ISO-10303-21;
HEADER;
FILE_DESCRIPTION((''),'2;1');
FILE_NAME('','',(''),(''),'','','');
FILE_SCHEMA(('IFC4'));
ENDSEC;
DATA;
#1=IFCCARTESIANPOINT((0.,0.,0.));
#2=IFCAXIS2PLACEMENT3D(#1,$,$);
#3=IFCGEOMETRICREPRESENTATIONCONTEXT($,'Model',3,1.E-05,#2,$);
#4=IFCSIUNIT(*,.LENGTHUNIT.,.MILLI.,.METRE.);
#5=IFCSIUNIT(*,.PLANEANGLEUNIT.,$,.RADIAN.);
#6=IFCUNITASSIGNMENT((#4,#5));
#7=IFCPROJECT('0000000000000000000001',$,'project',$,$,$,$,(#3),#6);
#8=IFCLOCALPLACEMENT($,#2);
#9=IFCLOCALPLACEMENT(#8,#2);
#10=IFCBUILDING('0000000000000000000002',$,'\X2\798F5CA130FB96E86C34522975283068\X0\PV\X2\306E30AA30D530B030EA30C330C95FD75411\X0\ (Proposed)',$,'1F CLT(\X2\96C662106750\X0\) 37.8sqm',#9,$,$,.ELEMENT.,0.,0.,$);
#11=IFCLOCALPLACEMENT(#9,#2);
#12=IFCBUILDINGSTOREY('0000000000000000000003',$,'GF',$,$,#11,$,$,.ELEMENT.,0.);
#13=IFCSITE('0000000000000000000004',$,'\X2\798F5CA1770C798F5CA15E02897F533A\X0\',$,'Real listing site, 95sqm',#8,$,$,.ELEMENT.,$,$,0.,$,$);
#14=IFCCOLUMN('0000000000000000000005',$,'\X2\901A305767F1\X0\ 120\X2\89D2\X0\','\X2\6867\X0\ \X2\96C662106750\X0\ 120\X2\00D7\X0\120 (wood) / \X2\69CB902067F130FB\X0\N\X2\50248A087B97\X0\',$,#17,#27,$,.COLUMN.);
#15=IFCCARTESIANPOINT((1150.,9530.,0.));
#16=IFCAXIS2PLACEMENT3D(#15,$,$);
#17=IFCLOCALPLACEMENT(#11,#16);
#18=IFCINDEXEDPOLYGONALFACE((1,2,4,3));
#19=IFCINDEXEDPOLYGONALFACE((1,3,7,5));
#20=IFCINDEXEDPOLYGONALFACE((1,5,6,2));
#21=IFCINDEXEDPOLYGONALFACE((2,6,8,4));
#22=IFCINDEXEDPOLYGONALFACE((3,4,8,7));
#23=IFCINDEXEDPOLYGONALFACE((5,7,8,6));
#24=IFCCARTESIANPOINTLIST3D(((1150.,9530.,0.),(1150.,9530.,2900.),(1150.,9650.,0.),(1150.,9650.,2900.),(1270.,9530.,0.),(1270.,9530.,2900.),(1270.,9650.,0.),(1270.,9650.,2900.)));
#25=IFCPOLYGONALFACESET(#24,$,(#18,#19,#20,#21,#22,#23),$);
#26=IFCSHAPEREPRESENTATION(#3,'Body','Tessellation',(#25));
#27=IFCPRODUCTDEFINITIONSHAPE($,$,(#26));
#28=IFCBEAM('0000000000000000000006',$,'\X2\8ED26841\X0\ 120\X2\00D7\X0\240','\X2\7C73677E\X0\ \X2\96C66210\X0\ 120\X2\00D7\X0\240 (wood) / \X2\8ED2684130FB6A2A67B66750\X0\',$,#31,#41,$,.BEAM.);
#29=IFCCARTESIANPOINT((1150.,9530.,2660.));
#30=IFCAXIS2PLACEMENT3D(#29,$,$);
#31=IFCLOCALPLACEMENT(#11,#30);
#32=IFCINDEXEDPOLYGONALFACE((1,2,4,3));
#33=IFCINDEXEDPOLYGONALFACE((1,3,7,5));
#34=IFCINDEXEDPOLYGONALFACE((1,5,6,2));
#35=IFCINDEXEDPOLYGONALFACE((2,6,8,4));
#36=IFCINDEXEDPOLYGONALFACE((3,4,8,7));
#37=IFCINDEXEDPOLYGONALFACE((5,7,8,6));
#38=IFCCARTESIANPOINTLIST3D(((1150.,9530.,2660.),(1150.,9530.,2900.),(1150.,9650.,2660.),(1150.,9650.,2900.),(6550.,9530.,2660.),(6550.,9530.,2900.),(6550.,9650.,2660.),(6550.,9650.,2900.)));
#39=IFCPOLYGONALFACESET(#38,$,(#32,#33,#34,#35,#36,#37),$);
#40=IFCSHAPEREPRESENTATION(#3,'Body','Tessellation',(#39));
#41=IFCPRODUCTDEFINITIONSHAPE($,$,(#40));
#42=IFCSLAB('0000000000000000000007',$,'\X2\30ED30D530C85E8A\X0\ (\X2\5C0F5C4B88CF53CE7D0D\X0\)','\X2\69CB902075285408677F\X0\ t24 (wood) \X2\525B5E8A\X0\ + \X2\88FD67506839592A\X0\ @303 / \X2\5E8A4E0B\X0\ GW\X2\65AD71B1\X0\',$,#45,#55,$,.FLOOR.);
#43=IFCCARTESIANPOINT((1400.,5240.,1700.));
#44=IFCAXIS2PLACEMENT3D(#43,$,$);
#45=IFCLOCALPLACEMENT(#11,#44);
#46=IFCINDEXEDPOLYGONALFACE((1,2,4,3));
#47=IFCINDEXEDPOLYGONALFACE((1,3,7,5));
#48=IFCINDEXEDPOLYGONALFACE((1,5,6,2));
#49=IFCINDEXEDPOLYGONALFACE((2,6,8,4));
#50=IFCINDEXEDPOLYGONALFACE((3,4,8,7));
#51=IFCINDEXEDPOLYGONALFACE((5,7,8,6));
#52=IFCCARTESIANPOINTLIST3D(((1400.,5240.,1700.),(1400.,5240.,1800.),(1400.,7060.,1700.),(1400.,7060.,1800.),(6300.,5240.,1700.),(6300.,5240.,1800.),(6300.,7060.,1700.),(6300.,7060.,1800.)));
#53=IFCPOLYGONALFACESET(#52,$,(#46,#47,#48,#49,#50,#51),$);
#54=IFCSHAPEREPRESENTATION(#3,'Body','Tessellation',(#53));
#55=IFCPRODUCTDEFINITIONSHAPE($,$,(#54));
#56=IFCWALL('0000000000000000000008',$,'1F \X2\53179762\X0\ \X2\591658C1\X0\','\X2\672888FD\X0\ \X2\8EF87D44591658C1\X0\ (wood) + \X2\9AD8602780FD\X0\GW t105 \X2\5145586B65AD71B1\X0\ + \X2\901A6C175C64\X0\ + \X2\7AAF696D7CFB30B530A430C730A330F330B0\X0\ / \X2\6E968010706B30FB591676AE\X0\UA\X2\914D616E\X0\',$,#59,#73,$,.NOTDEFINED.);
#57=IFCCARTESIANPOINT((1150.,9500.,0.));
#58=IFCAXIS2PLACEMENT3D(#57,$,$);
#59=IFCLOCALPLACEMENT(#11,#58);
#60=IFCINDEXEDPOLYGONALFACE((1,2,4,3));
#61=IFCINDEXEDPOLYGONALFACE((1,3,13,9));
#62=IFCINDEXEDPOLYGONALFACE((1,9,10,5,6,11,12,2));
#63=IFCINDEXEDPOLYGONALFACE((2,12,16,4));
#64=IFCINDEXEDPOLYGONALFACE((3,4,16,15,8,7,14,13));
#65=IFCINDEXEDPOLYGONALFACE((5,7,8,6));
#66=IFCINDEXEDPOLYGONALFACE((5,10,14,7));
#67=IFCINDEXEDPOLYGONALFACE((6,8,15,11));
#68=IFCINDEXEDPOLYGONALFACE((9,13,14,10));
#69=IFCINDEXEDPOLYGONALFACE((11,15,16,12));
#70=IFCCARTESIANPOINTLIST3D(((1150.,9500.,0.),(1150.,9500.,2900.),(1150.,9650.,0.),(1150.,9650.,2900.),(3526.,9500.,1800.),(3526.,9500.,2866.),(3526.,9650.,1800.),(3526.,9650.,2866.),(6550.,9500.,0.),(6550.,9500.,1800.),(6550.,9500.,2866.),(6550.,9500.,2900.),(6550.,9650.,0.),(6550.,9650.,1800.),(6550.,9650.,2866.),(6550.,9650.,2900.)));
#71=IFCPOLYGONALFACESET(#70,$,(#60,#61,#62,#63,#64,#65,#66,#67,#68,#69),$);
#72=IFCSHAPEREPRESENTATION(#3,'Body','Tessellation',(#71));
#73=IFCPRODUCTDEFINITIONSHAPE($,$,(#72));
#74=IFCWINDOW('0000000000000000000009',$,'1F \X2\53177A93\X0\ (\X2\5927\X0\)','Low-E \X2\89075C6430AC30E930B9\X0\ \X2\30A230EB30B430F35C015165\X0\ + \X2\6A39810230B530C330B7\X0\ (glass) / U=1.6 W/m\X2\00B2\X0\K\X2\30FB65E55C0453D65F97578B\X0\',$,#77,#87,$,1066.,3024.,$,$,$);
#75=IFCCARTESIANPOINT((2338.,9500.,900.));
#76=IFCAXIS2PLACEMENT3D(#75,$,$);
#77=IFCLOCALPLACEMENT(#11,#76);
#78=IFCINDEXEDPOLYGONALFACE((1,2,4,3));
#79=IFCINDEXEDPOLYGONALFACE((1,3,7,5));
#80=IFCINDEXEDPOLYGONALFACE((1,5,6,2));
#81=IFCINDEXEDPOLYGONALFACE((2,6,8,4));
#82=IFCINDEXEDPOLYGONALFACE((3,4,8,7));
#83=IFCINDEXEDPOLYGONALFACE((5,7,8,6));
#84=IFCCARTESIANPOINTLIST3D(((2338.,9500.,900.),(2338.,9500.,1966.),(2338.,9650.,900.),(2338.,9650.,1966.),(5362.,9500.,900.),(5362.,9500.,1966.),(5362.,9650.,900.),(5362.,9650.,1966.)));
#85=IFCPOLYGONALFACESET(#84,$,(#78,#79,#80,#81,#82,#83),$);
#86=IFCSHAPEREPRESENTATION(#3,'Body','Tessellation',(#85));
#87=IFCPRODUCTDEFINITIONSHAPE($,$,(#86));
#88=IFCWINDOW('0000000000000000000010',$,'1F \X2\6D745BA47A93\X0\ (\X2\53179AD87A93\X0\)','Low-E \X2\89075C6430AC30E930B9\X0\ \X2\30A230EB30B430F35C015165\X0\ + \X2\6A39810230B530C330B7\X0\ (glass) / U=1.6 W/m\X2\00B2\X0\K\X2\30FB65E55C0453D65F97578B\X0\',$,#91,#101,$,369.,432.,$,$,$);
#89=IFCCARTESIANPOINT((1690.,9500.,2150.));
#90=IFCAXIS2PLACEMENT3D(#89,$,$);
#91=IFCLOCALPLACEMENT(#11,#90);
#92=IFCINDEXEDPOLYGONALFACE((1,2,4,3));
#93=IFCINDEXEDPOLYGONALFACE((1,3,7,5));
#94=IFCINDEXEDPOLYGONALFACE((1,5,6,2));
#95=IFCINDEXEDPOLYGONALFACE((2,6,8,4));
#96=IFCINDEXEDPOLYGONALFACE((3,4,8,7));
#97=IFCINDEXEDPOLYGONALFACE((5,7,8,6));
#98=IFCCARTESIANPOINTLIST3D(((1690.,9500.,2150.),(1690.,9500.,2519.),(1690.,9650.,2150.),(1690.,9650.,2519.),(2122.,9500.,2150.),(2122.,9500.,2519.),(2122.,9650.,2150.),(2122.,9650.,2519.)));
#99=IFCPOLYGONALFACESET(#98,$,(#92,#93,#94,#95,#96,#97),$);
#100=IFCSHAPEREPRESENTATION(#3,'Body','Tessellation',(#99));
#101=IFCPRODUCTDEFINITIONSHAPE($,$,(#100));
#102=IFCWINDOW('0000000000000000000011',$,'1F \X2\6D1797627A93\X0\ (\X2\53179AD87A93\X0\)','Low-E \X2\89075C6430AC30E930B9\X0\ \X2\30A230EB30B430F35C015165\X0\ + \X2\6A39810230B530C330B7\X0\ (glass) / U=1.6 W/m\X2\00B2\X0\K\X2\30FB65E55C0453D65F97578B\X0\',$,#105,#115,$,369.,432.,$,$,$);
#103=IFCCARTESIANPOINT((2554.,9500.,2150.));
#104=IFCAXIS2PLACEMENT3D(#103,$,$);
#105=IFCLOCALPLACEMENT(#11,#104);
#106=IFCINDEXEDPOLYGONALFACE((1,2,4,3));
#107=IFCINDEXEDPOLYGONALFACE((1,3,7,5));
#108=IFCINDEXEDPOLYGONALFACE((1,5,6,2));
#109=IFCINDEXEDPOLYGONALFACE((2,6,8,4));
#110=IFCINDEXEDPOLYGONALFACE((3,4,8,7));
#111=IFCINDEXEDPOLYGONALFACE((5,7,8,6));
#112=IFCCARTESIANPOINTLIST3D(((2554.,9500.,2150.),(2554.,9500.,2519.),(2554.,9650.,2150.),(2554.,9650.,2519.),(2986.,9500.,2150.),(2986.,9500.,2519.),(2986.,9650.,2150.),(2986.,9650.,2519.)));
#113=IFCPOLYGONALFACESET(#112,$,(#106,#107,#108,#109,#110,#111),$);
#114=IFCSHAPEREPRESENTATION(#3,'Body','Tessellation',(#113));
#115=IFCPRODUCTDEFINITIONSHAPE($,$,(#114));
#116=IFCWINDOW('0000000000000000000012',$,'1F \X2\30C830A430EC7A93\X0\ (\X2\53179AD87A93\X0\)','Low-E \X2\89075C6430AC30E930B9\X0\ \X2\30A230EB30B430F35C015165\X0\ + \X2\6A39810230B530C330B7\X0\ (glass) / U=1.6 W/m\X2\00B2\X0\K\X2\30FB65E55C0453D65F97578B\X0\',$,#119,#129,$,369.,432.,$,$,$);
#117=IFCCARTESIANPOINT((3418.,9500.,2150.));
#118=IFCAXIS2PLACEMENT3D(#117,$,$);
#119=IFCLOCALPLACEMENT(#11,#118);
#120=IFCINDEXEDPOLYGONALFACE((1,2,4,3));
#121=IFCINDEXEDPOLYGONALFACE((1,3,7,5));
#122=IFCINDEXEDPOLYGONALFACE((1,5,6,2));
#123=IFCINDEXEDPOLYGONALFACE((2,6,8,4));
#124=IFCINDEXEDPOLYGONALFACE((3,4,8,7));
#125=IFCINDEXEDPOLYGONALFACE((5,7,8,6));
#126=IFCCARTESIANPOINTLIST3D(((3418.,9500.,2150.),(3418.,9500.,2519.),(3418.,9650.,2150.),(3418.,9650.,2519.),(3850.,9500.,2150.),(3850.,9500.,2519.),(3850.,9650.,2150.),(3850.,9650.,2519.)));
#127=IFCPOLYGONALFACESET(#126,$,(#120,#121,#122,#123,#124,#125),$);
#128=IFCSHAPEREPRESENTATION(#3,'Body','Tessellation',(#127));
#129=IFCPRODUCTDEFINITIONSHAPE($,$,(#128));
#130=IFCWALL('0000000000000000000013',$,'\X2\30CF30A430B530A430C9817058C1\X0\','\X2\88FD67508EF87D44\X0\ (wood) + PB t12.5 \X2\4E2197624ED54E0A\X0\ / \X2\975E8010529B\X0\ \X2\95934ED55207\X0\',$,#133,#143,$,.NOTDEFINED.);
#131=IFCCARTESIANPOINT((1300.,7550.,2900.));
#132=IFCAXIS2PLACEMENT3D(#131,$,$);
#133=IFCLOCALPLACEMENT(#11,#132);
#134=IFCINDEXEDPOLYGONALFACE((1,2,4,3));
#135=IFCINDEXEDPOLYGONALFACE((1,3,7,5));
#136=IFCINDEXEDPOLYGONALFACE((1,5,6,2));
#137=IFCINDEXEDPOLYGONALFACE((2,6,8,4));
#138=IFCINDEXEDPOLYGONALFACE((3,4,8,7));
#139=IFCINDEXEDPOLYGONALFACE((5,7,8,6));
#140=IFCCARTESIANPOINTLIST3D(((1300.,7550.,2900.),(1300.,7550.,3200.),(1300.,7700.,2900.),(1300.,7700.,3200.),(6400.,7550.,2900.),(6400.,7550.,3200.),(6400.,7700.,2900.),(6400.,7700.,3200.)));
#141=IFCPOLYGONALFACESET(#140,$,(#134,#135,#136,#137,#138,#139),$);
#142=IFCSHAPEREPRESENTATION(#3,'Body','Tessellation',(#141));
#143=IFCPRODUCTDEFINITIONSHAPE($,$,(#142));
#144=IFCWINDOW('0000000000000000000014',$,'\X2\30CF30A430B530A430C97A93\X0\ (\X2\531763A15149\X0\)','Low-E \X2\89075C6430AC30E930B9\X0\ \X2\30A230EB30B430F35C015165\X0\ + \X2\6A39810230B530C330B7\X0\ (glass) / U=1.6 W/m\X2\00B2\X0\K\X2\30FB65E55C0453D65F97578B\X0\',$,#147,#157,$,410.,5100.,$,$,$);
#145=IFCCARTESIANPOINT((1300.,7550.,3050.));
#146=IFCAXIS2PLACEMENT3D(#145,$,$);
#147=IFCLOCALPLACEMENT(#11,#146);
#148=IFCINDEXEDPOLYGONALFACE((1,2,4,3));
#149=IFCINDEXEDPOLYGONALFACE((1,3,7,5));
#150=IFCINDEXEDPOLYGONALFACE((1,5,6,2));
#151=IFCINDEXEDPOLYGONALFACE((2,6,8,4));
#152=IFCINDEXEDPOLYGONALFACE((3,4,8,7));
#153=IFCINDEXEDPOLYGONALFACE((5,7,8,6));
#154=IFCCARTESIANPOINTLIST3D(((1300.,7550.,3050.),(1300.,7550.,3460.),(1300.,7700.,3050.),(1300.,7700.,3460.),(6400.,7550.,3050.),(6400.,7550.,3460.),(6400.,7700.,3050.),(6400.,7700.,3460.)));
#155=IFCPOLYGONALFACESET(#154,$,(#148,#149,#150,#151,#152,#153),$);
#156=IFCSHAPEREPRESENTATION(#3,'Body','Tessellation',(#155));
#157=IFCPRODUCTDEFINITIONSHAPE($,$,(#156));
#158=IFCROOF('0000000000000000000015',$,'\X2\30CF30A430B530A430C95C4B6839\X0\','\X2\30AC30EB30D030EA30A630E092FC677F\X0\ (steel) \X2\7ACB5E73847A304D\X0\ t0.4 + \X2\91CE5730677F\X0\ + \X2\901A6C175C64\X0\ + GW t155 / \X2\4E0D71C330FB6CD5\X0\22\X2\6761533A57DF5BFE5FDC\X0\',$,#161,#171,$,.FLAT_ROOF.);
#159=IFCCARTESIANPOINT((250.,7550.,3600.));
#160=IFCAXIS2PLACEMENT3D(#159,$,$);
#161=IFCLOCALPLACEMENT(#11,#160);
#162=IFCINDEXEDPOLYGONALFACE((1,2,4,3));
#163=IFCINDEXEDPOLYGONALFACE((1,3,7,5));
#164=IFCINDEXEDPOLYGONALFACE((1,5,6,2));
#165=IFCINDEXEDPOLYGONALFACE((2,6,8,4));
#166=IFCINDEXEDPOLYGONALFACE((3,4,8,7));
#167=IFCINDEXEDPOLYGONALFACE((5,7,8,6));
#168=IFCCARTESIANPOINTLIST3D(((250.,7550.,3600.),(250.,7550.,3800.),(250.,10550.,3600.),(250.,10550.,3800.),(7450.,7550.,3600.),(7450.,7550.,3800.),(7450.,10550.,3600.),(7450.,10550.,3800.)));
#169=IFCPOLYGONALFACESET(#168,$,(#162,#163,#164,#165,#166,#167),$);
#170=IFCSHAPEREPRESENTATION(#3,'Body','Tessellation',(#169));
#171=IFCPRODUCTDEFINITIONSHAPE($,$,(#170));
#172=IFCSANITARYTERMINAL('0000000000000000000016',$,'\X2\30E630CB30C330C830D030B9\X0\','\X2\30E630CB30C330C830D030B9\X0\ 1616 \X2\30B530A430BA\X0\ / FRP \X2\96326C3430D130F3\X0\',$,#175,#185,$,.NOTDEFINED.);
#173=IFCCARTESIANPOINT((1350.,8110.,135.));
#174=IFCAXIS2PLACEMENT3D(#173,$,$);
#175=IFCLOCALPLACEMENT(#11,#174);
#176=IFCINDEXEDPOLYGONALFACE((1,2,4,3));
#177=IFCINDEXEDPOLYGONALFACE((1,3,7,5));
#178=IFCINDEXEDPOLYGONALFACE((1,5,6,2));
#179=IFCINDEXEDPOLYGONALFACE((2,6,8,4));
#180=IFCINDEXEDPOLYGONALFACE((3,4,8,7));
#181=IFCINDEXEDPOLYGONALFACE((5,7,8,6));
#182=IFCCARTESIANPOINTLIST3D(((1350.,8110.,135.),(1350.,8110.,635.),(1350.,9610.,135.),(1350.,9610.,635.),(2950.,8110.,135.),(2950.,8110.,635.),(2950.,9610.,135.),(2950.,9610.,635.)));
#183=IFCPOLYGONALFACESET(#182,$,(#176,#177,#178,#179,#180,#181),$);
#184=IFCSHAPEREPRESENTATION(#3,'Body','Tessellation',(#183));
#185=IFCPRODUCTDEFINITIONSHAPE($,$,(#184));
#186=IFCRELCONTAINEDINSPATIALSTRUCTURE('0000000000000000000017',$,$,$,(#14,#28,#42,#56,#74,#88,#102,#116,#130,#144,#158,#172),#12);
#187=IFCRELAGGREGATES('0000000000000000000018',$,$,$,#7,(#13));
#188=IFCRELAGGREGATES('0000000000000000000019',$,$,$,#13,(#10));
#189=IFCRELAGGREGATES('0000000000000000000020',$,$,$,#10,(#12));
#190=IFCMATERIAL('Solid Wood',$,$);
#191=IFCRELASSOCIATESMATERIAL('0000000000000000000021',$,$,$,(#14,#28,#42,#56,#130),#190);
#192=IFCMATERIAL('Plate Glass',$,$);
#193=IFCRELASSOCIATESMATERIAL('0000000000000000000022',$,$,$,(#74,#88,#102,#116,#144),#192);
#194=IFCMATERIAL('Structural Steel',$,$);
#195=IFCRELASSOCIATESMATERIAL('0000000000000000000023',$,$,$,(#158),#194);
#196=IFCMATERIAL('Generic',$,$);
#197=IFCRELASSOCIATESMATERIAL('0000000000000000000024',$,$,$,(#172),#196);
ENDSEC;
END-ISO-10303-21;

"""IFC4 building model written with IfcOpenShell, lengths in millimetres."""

from ifc_helpers import new_model, si_unit, frame, frame_2d, origin, place, context, project, spatial, rectangle, extrude, material, element, fill, save


model = new_model("IFC4")

# Units and contexts
model_context = context("Model", 3, precision=1e-05, world=origin())
ifc_project = project(units=[si_unit("LENGTHUNIT", "METRE", prefix="MILLI"), si_unit("PLANEANGLEUNIT", "RADIAN")], contexts=[model_context])

# Site, building, storey
site_placement = place(None, origin())
site = spatial("IfcSite", under=ifc_project, at=site_placement, Name="福岡県福岡市西区", ObjectType="Real listing site, 95sqm", CompositionType="ELEMENT", RefElevation=0.0)
building_placement = place(site_placement, origin())
building = spatial("IfcBuilding", under=site, at=building_placement, Name="福岡・雨水利用とPVのオフグリッド志向 (Proposed)", ObjectType="1F CLT(集成材) 37.8sqm", CompositionType="ELEMENT", ElevationOfRefHeight=0.0, ElevationOfTerrain=0.0)
storey_placement = place(building_placement, origin())
storey = spatial("IfcBuildingStorey", under=building, at=storey_placement, Name="GF", CompositionType="ELEMENT", Elevation=0.0)

# Column
ifc_material_1 = material(Name="Solid Wood")
column_1_placement = place(storey_placement, frame((1150.0, 9530.0, 0.0)))
element("IfcColumn", 1, at=column_1_placement, inside=storey, material=ifc_material_1, Name="通し柱 120角", Description="桧 集成材 120×120 (wood) / 構造柱・N値計算", PredefinedType="COLUMN", context=model_context, shape_type="SweptSolid", body=[
    extrude(rectangle(XDim=120.0, YDim=120.0, at=frame_2d((60.0, 60.0))), frame((1150.0, 9530.0, 0.0)), (0.0, 0.0, 1.0), 2900.0),
])

# Beam
beam_1_placement = place(storey_placement, frame((1150.0, 9530.0, 2660.0)))
element("IfcBeam", 2, at=beam_1_placement, inside=storey, material=ifc_material_1, Name="軒桁 120×240", Description="米松 集成 120×240 (wood) / 軒桁・横架材", PredefinedType="BEAM", context=model_context, shape_type="SweptSolid", body=[
    extrude(rectangle(XDim=5400.0, YDim=120.0, at=frame_2d((2700.0, 60.0))), frame((1150.0, 9530.0, 2660.0)), (0.0, 0.0, 1.0), 240.0),
])

# Slab
slab_placement = place(storey_placement, frame((1400.0, 5240.0, 1700.0)))
element("IfcSlab", 3, at=slab_placement, inside=storey, material=ifc_material_1, Name="ロフト床 (小屋裏収納)", Description="構造用合板 t24 (wood) 剛床 + 製材根太 @303 / 床下 GW断熱", PredefinedType="FLOOR", context=model_context, shape_type="SweptSolid", body=[
    extrude(rectangle(XDim=4900.0, YDim=1820.0, at=frame_2d((2450.0, 910.0))), frame((1400.0, 5240.0, 1700.0)), (0.0, 0.0, 1.0), 100.0),
])

# Wall, openings, windows
wall_1_placement = place(storey_placement, frame((1150.0, 9500.0, 0.0)))
wall_1 = element("IfcWall", 4, at=wall_1_placement, inside=storey, material=ifc_material_1, Name="1F 北面 外壁", Description="木製 軸組外壁 (wood) + 高性能GW t105 充填断熱 + 通気層 + 窯業系サイディング / 準耐火・外皮UA配慮", PredefinedType="NOTDEFINED", context=model_context, shape_type="SweptSolid", body=[
    extrude(rectangle(XDim=5400.0, YDim=150.0, at=frame_2d((2700.0, 75.0))), frame((1150.0, 9500.0, 0.0)), (0.0, 0.0, 1.0), 2900.0),
])
opening_1_placement = place(storey_placement, frame((2338.0, 9500.0, 900.0)))
opening_1 = element("IfcOpeningElement", 5, at=opening_1_placement, cuts=wall_1, PredefinedType="NOTDEFINED", context=model_context, shape_type="SweptSolid", body=[
    extrude(rectangle(XDim=3024.0, YDim=150.0, at=frame_2d((1512.0, 75.0))), frame((2338.0, 9500.0, 900.0)), (0.0, 0.0, 1.0), 1066.0),
])
opening_2_placement = place(storey_placement, frame((1690.0, 9500.0, 2150.0)))
opening_2 = element("IfcOpeningElement", 6, at=opening_2_placement, cuts=wall_1, PredefinedType="NOTDEFINED", context=model_context, shape_type="SweptSolid", body=[
    extrude(rectangle(XDim=432.0, YDim=150.0, at=frame_2d((216.0, 75.0))), frame((1690.0, 9500.0, 2150.0)), (0.0, 0.0, 1.0), 369.0),
])
opening_3_placement = place(storey_placement, frame((2554.0, 9500.0, 2150.0)))
opening_3 = element("IfcOpeningElement", 7, at=opening_3_placement, cuts=wall_1, PredefinedType="NOTDEFINED", context=model_context, shape_type="SweptSolid", body=[
    extrude(rectangle(XDim=432.0, YDim=150.0, at=frame_2d((216.0, 75.0))), frame((2554.0, 9500.0, 2150.0)), (0.0, 0.0, 1.0), 369.0),
])
opening_4_placement = place(storey_placement, frame((3418.0, 9500.0, 2150.0)))
opening_4 = element("IfcOpeningElement", 8, at=opening_4_placement, cuts=wall_1, PredefinedType="NOTDEFINED", context=model_context, shape_type="SweptSolid", body=[
    extrude(rectangle(XDim=432.0, YDim=150.0, at=frame_2d((216.0, 75.0))), frame((3418.0, 9500.0, 2150.0)), (0.0, 0.0, 1.0), 369.0),
])
ifc_material_2 = material(Name="Plate Glass")
window_1_placement = place(storey_placement, frame((2338.0, 9500.0, 900.0)))
window_1 = element("IfcWindow", 9, at=window_1_placement, inside=storey, material=ifc_material_2, Name="1F 北窓 (大)", Description="Low-E 複層ガラス アルゴン封入 + 樹脂サッシ (glass) / U=1.6 W/m²K・日射取得型", OverallHeight=1066.0, OverallWidth=3024.0, context=model_context, shape_type="SweptSolid", body=[
    extrude(rectangle(XDim=3024.0, YDim=150.0, at=frame_2d((1512.0, 75.0))), frame((2338.0, 9500.0, 900.0)), (0.0, 0.0, 1.0), 1066.0),
])
fill(opening_1, window_1)
window_2_placement = place(storey_placement, frame((1690.0, 9500.0, 2150.0)))
window_2 = element("IfcWindow", 10, at=window_2_placement, inside=storey, material=ifc_material_2, Name="1F 浴室窓 (北高窓)", Description="Low-E 複層ガラス アルゴン封入 + 樹脂サッシ (glass) / U=1.6 W/m²K・日射取得型", OverallHeight=369.0, OverallWidth=432.0, context=model_context, shape_type="SweptSolid", body=[
    extrude(rectangle(XDim=432.0, YDim=150.0, at=frame_2d((216.0, 75.0))), frame((1690.0, 9500.0, 2150.0)), (0.0, 0.0, 1.0), 369.0),
])
fill(opening_2, window_2)
window_3_placement = place(storey_placement, frame((2554.0, 9500.0, 2150.0)))
window_3 = element("IfcWindow", 11, at=window_3_placement, inside=storey, material=ifc_material_2, Name="1F 洗面窓 (北高窓)", Description="Low-E 複層ガラス アルゴン封入 + 樹脂サッシ (glass) / U=1.6 W/m²K・日射取得型", OverallHeight=369.0, OverallWidth=432.0, context=model_context, shape_type="SweptSolid", body=[
    extrude(rectangle(XDim=432.0, YDim=150.0, at=frame_2d((216.0, 75.0))), frame((2554.0, 9500.0, 2150.0)), (0.0, 0.0, 1.0), 369.0),
])
fill(opening_3, window_3)
window_4_placement = place(storey_placement, frame((3418.0, 9500.0, 2150.0)))
window_4 = element("IfcWindow", 12, at=window_4_placement, inside=storey, material=ifc_material_2, Name="1F トイレ窓 (北高窓)", Description="Low-E 複層ガラス アルゴン封入 + 樹脂サッシ (glass) / U=1.6 W/m²K・日射取得型", OverallHeight=369.0, OverallWidth=432.0, context=model_context, shape_type="SweptSolid", body=[
    extrude(rectangle(XDim=432.0, YDim=150.0, at=frame_2d((216.0, 75.0))), frame((3418.0, 9500.0, 2150.0)), (0.0, 0.0, 1.0), 369.0),
])
fill(opening_4, window_4)

# Wall, opening, window
wall_2_placement = place(storey_placement, frame((1300.0, 7550.0, 2900.0)))
wall_2 = element("IfcWall", 13, at=wall_2_placement, inside=storey, material=ifc_material_1, Name="ハイサイド腰壁", Description="製材軸組 (wood) + PB t12.5 両面仕上 / 非耐力 間仕切", PredefinedType="NOTDEFINED", context=model_context, shape_type="SweptSolid", body=[
    extrude(rectangle(XDim=5100.0, YDim=150.0, at=frame_2d((2550.0, 75.0))), frame((1300.0, 7550.0, 2900.0)), (0.0, 0.0, 1.0), 700.0),
])
opening_5_placement = place(storey_placement, frame((1300.0, 7550.0, 3050.0)))
opening_5 = element("IfcOpeningElement", 14, at=opening_5_placement, cuts=wall_2, PredefinedType="NOTDEFINED", context=model_context, shape_type="SweptSolid", body=[
    extrude(rectangle(XDim=5100.0, YDim=150.0, at=frame_2d((2550.0, 75.0))), frame((1300.0, 7550.0, 3050.0)), (0.0, 0.0, 1.0), 410.0),
])
window_5_placement = place(storey_placement, frame((1300.0, 7550.0, 3050.0)))
window_5 = element("IfcWindow", 15, at=window_5_placement, inside=storey, material=ifc_material_2, Name="ハイサイド窓 (北採光)", Description="Low-E 複層ガラス アルゴン封入 + 樹脂サッシ (glass) / U=1.6 W/m²K・日射取得型", OverallHeight=410.0, OverallWidth=5100.0, context=model_context, shape_type="SweptSolid", body=[
    extrude(rectangle(XDim=5100.0, YDim=150.0, at=frame_2d((2550.0, 75.0))), frame((1300.0, 7550.0, 3050.0)), (0.0, 0.0, 1.0), 410.0),
])
fill(opening_5, window_5)

# Roof
ifc_material_3 = material(Name="Structural Steel")
roof_placement = place(storey_placement, frame((250.0, 7550.0, 3600.0)))
element("IfcRoof", 16, at=roof_placement, inside=storey, material=ifc_material_3, Name="ハイサイド屋根", Description="ガルバリウム鋼板 (steel) 立平葺き t0.4 + 野地板 + 通気層 + GW t155 / 不燃・法22条区域対応", PredefinedType="FLAT_ROOF", context=model_context, shape_type="SweptSolid", body=[
    extrude(rectangle(XDim=7200.0, YDim=3000.0, at=frame_2d((3600.0, 1500.0))), frame((250.0, 7550.0, 3600.0)), (0.0, 0.0, 1.0), 200.0),
])

# Sanitary terminal
ifc_material_4 = material(Name="Generic")
sanitary_terminal_placement = place(storey_placement, frame((1350.0, 8110.0, 135.0)))
element("IfcSanitaryTerminal", 17, at=sanitary_terminal_placement, inside=storey, material=ifc_material_4, Name="ユニットバス", Description="ユニットバス 1616 サイズ / FRP 防水パン", PredefinedType="NOTDEFINED", context=model_context, shape_type="SweptSolid", body=[
    extrude(rectangle(XDim=1600.0, YDim=1500.0, at=frame_2d((800.0, 750.0))), frame((1350.0, 8110.0, 135.0)), (0.0, 0.0, 1.0), 500.0),
])

save(model, "model.ifc")
